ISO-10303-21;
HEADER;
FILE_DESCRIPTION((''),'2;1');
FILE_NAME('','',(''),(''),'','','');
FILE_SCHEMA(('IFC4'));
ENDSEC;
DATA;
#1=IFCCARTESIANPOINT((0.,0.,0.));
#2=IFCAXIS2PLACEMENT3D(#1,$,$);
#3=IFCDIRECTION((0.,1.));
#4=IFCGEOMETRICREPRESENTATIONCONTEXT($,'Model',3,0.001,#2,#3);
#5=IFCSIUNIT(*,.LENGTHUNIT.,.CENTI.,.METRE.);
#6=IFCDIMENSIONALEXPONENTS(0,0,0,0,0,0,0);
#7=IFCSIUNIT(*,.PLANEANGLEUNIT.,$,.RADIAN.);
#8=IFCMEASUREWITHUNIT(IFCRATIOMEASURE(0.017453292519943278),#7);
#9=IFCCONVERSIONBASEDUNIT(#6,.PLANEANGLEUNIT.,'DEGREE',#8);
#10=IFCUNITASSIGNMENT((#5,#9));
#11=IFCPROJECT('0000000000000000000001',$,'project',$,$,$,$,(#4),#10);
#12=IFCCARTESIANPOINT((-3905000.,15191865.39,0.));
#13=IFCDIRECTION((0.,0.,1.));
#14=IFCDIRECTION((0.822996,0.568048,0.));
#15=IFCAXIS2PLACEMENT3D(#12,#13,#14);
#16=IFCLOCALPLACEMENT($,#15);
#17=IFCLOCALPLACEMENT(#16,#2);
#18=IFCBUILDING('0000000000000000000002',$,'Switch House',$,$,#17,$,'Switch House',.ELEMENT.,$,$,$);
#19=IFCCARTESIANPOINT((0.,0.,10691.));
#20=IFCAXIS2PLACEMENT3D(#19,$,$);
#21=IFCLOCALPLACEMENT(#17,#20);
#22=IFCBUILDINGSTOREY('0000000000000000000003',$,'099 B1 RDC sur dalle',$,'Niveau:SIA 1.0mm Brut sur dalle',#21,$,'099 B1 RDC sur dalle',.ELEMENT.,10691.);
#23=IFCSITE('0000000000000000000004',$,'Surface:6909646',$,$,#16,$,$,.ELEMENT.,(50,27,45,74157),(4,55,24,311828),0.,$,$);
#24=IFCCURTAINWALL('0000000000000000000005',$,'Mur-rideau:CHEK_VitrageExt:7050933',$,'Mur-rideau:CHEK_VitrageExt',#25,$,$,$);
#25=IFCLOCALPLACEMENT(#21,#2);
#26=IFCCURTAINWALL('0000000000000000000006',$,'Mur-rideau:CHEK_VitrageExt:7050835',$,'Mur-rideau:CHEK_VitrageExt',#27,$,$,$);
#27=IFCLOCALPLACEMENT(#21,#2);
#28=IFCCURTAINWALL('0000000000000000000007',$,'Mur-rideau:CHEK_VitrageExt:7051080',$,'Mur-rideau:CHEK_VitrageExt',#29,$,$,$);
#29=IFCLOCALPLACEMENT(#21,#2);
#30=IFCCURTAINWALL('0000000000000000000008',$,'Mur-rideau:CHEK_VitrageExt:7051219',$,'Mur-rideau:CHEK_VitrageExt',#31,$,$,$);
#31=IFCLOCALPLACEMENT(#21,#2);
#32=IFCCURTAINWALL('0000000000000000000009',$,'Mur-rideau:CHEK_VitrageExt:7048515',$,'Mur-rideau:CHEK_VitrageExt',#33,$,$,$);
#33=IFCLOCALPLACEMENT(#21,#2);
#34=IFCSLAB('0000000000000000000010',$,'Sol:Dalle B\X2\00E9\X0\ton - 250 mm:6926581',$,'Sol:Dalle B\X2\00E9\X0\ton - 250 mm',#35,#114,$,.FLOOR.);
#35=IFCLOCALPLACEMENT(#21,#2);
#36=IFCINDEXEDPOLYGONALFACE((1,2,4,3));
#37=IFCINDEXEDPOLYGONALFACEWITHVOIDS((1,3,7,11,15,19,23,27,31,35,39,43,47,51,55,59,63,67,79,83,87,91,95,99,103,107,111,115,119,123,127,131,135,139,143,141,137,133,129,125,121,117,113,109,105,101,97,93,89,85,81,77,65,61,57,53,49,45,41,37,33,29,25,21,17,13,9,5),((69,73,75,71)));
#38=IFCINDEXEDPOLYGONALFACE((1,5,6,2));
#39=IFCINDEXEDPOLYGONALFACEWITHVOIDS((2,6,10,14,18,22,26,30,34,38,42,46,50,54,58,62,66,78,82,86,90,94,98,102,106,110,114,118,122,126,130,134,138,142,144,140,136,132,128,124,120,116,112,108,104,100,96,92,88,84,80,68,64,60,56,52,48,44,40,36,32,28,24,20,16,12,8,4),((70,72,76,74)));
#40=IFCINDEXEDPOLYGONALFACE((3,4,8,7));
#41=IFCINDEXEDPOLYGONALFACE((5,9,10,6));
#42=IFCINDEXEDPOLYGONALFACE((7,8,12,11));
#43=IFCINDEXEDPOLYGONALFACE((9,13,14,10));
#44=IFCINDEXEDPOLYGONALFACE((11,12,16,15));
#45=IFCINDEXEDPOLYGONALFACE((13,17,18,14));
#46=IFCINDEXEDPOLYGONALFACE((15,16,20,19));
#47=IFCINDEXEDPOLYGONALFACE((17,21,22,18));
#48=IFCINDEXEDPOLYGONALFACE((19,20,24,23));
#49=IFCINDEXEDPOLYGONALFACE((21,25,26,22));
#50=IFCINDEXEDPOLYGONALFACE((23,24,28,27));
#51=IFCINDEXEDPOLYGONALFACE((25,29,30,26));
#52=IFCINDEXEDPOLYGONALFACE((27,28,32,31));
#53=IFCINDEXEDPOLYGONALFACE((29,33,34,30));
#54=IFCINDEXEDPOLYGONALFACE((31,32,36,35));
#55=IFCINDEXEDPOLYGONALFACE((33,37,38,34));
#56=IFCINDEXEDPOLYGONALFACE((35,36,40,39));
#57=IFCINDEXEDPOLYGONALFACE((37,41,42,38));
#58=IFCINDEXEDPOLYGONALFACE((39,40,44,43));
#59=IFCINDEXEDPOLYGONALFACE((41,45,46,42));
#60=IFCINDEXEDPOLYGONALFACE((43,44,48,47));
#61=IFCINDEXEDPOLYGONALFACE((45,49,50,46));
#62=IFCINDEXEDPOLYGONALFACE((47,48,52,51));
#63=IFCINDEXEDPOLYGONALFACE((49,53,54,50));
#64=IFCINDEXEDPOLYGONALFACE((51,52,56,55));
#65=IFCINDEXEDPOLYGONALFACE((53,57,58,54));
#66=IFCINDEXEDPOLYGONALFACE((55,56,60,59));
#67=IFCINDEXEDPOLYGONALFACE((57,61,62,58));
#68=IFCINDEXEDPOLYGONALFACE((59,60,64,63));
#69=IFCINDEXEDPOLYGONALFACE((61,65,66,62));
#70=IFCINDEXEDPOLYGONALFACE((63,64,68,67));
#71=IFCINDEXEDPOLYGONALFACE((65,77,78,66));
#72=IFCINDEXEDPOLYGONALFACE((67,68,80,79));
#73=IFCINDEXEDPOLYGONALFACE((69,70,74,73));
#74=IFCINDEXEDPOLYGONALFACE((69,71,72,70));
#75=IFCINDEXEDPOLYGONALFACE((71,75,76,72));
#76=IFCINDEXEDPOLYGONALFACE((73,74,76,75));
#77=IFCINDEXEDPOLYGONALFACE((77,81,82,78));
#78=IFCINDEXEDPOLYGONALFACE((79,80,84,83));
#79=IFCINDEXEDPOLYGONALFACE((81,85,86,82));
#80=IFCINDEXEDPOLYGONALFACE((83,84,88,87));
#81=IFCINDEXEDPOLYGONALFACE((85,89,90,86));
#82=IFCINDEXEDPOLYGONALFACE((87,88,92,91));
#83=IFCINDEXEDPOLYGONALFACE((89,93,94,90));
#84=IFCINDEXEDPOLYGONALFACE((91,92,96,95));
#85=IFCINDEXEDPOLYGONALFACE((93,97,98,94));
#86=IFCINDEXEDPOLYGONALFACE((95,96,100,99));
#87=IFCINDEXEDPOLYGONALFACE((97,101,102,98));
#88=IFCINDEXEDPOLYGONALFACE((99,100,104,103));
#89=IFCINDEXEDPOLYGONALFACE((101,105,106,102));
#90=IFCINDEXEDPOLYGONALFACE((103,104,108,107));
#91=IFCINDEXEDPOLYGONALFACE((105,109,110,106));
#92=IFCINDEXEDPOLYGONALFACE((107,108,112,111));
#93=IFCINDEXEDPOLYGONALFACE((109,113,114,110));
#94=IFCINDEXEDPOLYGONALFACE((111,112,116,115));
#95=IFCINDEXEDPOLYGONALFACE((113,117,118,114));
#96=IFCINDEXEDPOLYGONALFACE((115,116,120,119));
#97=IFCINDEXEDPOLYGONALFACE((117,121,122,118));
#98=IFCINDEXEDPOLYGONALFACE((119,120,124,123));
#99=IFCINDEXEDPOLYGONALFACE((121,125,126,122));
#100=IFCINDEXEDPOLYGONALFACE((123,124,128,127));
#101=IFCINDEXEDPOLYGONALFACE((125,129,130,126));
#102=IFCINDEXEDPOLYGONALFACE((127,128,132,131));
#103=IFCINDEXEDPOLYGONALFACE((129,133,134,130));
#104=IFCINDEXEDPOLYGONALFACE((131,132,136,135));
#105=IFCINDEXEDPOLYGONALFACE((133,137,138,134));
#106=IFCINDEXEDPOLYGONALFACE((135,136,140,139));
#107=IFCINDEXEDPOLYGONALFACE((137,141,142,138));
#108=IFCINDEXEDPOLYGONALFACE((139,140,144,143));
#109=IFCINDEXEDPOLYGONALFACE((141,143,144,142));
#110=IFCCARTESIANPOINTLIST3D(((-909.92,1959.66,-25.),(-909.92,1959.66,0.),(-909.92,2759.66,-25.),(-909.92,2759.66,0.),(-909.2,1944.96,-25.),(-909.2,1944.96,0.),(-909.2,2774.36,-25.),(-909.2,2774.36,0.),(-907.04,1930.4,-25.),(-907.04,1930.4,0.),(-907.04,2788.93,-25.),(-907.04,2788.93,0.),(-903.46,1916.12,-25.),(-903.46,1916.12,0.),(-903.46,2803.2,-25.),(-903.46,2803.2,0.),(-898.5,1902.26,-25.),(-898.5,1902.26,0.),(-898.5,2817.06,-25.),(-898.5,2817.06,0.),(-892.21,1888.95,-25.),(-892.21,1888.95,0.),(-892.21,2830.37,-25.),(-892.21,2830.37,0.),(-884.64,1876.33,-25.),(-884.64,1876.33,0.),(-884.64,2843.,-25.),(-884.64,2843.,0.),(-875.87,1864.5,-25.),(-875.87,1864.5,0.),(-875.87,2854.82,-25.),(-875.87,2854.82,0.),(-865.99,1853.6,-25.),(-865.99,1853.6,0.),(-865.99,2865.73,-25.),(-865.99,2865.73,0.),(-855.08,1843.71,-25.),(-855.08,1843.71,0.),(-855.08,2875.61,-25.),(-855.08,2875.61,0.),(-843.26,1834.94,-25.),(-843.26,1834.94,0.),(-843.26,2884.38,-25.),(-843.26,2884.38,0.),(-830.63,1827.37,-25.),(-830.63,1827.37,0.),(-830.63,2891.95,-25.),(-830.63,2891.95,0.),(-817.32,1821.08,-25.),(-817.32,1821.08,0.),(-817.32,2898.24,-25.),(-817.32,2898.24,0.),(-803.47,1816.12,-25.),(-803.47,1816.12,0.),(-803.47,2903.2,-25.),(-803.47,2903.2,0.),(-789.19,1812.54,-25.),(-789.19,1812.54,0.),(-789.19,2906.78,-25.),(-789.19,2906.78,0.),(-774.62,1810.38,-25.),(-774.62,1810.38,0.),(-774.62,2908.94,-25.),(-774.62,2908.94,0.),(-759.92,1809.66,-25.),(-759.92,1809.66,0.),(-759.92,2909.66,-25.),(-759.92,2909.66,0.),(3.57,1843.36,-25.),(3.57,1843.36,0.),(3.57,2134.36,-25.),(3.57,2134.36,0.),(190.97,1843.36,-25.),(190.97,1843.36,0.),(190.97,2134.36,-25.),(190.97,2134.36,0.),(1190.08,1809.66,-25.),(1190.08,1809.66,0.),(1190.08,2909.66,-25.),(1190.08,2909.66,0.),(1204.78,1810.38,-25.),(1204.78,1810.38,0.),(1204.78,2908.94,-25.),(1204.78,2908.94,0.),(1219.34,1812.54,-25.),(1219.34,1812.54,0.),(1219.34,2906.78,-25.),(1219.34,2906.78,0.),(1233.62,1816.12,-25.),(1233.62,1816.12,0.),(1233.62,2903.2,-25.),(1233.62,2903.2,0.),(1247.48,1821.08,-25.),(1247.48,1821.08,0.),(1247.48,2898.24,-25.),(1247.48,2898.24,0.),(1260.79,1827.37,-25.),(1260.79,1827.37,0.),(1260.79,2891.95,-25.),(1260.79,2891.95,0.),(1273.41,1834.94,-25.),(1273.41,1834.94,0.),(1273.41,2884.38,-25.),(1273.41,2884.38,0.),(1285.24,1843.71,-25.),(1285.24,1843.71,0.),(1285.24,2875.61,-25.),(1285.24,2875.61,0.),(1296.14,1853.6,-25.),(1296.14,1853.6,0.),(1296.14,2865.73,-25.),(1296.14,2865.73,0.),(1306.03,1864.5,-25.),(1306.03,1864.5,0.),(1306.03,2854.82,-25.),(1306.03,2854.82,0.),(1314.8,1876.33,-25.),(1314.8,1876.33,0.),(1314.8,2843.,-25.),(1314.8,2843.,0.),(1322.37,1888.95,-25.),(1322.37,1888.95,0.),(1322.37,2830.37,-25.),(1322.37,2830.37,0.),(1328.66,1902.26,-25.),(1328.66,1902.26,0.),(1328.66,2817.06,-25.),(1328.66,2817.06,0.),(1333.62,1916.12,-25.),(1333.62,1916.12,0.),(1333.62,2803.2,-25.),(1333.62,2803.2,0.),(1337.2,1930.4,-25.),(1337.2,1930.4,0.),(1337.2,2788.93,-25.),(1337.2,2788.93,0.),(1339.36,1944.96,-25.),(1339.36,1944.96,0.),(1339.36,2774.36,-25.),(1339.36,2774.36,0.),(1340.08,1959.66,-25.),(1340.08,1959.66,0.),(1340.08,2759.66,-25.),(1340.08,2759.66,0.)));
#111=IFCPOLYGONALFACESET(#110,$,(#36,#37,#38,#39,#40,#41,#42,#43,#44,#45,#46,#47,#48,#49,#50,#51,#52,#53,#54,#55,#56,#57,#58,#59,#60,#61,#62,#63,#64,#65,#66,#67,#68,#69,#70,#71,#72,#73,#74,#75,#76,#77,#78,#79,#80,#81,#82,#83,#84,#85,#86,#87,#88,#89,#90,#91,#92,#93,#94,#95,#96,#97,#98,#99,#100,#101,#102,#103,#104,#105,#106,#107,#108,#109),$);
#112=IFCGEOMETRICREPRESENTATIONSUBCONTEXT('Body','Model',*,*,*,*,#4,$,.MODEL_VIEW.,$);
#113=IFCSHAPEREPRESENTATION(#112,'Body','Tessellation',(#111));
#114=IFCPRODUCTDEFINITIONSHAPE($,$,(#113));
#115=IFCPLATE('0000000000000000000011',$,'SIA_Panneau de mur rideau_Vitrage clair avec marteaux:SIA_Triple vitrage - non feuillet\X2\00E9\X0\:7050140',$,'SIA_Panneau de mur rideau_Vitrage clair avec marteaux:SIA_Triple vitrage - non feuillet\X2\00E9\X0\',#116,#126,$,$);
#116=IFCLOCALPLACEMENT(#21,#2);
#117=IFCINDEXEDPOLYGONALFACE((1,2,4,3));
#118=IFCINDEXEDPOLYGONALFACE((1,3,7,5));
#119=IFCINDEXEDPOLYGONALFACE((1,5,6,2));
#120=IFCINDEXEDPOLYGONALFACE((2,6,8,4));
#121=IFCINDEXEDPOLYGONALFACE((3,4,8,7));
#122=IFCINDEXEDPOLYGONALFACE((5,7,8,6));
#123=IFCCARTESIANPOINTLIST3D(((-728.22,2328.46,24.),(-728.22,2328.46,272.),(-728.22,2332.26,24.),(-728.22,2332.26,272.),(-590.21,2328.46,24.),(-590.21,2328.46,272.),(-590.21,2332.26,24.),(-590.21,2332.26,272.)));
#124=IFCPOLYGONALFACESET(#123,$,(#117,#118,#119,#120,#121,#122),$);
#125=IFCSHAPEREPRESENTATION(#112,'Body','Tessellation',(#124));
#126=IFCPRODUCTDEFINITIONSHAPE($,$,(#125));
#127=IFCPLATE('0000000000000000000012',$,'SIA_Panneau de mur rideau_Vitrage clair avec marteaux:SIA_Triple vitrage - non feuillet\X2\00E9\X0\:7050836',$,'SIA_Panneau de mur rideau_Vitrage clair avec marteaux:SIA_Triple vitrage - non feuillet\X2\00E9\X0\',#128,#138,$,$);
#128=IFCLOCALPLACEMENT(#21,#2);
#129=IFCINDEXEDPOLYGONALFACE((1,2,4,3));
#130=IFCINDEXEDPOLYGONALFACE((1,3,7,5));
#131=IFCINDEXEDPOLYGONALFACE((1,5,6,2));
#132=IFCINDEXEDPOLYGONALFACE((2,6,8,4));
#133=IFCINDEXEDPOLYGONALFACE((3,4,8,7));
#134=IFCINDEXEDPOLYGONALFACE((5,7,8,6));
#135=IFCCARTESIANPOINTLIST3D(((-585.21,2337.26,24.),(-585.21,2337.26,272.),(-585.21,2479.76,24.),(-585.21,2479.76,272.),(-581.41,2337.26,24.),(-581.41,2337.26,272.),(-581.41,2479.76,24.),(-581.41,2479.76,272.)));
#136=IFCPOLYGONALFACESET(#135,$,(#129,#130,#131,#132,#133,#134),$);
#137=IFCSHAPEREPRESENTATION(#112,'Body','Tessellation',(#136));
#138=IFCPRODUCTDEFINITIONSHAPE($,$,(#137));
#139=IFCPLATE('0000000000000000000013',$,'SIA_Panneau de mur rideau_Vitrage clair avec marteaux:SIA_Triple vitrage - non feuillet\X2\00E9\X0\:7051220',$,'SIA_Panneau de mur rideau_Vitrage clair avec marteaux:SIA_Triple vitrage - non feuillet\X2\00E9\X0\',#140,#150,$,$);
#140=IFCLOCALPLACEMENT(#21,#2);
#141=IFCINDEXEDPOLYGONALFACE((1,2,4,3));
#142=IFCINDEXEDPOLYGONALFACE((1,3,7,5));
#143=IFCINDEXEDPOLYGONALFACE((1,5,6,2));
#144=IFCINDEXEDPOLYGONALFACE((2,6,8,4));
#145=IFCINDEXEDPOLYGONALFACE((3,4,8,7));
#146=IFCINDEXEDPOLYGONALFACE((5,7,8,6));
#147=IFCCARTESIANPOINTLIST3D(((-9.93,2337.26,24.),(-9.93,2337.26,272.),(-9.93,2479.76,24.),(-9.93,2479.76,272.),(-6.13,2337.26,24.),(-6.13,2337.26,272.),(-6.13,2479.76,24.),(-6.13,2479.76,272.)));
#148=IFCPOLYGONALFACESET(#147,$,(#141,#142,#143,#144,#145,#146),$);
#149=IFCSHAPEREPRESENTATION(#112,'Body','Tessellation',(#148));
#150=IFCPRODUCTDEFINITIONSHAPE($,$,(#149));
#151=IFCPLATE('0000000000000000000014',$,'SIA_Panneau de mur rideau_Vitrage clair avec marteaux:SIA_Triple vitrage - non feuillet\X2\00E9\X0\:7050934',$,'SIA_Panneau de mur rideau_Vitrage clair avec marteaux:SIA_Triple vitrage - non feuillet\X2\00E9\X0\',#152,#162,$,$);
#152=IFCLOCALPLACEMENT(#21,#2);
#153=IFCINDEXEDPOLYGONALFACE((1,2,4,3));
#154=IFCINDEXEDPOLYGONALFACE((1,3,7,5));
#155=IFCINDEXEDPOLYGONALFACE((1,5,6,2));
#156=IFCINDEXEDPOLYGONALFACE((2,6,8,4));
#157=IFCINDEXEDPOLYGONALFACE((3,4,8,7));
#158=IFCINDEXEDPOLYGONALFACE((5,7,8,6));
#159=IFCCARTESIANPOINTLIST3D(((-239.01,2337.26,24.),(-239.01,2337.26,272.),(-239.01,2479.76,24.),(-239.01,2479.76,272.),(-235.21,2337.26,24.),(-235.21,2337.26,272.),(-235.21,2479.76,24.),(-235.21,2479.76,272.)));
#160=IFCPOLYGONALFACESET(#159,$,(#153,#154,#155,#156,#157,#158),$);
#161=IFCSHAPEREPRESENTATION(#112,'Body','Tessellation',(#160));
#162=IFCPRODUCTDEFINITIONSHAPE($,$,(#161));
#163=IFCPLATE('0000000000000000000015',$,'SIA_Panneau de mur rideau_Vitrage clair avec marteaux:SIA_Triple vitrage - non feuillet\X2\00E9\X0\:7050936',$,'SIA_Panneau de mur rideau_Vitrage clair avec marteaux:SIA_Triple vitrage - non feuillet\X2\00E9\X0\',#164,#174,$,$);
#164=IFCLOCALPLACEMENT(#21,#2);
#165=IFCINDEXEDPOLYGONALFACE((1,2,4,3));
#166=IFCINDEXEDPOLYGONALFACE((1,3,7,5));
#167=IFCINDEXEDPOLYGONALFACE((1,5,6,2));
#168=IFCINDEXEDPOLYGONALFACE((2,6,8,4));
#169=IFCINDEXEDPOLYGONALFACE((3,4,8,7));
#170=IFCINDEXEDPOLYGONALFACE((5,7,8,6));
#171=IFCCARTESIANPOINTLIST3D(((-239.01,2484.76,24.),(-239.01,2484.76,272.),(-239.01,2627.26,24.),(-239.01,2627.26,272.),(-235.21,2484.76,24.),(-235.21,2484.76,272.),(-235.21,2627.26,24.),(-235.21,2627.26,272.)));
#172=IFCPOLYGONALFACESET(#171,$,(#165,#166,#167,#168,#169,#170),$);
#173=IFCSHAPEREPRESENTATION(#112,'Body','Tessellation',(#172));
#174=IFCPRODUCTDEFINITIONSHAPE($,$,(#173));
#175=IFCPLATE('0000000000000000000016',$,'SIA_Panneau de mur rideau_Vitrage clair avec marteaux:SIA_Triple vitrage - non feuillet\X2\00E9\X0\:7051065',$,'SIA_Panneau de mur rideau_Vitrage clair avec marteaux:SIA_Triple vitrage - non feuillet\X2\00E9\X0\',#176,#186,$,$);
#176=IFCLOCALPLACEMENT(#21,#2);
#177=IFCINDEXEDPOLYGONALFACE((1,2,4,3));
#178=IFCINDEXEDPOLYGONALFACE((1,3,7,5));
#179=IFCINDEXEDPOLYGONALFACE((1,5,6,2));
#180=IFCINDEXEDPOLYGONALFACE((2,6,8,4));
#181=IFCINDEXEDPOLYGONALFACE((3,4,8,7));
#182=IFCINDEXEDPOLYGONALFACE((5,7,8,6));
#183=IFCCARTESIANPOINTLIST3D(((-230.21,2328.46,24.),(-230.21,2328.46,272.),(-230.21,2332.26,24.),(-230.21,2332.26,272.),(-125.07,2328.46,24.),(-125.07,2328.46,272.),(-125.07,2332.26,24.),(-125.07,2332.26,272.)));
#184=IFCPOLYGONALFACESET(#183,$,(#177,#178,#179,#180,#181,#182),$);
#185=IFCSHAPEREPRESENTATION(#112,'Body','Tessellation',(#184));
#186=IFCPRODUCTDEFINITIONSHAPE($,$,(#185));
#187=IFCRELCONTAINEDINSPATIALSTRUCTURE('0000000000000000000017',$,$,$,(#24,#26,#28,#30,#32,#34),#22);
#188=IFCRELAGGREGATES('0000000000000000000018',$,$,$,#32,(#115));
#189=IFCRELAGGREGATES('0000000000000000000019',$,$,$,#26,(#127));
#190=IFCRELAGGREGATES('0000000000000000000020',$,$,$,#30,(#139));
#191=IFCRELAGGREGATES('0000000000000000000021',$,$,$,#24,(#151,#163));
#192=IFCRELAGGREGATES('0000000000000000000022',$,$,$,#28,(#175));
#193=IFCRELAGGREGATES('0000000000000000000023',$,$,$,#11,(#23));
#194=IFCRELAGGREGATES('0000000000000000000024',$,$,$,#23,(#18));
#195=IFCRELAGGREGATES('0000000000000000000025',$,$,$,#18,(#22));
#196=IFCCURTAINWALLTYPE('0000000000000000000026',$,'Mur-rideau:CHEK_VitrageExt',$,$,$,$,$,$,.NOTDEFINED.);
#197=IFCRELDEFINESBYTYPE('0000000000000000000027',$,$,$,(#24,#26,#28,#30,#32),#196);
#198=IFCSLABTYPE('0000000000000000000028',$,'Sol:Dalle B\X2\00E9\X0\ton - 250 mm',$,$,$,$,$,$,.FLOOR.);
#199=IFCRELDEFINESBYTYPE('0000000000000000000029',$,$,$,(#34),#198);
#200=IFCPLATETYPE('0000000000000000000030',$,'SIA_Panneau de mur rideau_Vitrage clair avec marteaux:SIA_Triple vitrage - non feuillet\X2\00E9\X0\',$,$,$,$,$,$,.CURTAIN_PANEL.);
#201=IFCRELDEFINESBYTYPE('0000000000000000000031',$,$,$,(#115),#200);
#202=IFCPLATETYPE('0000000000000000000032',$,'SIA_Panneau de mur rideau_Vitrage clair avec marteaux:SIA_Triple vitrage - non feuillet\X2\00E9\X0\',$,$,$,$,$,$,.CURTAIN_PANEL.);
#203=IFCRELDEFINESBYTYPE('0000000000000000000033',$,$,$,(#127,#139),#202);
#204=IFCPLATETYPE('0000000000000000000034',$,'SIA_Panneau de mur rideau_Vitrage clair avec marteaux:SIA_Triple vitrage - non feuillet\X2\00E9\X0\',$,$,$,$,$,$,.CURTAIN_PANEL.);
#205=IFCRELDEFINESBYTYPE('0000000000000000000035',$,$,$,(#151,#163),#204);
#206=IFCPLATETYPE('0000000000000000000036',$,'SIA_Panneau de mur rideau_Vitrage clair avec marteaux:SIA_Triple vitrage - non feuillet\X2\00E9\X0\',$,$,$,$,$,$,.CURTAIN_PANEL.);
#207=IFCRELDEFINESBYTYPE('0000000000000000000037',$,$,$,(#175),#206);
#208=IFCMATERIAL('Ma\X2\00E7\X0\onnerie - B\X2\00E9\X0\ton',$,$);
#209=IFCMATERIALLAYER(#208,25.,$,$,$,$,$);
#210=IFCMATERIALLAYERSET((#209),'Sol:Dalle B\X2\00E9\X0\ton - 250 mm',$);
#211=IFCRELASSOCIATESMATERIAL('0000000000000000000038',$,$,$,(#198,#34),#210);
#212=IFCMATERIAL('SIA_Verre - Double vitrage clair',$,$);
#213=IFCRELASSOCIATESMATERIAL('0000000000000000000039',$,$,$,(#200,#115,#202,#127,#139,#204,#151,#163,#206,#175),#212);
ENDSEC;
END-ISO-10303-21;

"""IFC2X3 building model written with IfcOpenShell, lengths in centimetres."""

from ifc_helpers import new_model, entity, si_unit, converted_unit, direction, frame, frame_2d, origin, origin_2d_with_axis, place, context, subcontext, project, spatial, polyline, circle_curve, parameter, trimmed, segment, composite_curve, rectangle, outline, extrude, source, transform, mapped, material, layer, layer_set, layer_usage, type_object, type_shapes, element, aggregate, save


model = new_model("IFC2X3")

# Units and contexts
model_context = context("Model", 3, precision=0.001, world=origin(), true_north=direction((0.0, 1.0)))
body_context = subcontext(model_context, "Body", "Model", "MODEL_VIEW")
ifc_project = project(units=[si_unit("LENGTHUNIT", "METRE", prefix="CENTI"), converted_unit("PLANEANGLEUNIT", "DEGREE", entity("IfcRatioMeasure", 0.017453292519943278), si_unit("PLANEANGLEUNIT", "RADIAN"), dimensions=[0, 0, 0, 0, 0, 0, 0])], contexts=[model_context])

# Site, building, storey
site_placement = place(None, frame((-3905000.0, 15191865.39, 0.0), z_axis=(0.0, 0.0, 1.0), x_axis=(0.822996, 0.568048, 0.0)))
site = spatial("IfcSite", under=ifc_project, at=site_placement, Name="Surface:6909646", CompositionType="ELEMENT", RefLatitude=(50, 27, 45, 74157), RefLongitude=(4, 55, 24, 311828), RefElevation=0.0)
building_placement = place(site_placement, origin())
building = spatial("IfcBuilding", under=site, at=building_placement, Name="Switch House", LongName="Switch House", CompositionType="ELEMENT")
storey_placement = place(building_placement, frame((0.0, 0.0, 10691.0)))
storey = spatial("IfcBuildingStorey", under=building, at=storey_placement, Name="099 B1 RDC sur dalle", ObjectType="Niveau:SIA 1.0mm Brut sur dalle", LongName="099 B1 RDC sur dalle", CompositionType="ELEMENT", Elevation=10691.0)

# Curtain wall
curtain_wall_type = type_object("IfcCurtainWallType", Name="Mur-rideau:CHEK_VitrageExt", PredefinedType="NOTDEFINED")
curtain_wall_1_placement = place(storey_placement, frame((0.0, 0.0, -10691.0)))
curtain_wall_1 = element("IfcCurtainWall", 1, at=curtain_wall_1_placement, inside=storey, type_object=curtain_wall_type, Name="Mur-rideau:CHEK_VitrageExt:7050933", ObjectType="Mur-rideau:CHEK_VitrageExt")

# Curtain walls
curtain_wall_2_placement = place(storey_placement, frame((0.0, 0.0, -10691.0)))
curtain_wall_2 = element("IfcCurtainWall", 2, at=curtain_wall_2_placement, inside=storey, type_object=curtain_wall_type, Name="Mur-rideau:CHEK_VitrageExt:7050835", ObjectType="Mur-rideau:CHEK_VitrageExt")
curtain_wall_3_placement = place(storey_placement, frame((0.0, 0.0, -10691.0)))
curtain_wall_3 = element("IfcCurtainWall", 3, at=curtain_wall_3_placement, inside=storey, type_object=curtain_wall_type, Name="Mur-rideau:CHEK_VitrageExt:7051080", ObjectType="Mur-rideau:CHEK_VitrageExt")
curtain_wall_4_placement = place(storey_placement, frame((0.0, 0.0, -10691.0)))
curtain_wall_4 = element("IfcCurtainWall", 4, at=curtain_wall_4_placement, inside=storey, type_object=curtain_wall_type, Name="Mur-rideau:CHEK_VitrageExt:7051219", ObjectType="Mur-rideau:CHEK_VitrageExt")

# Curtain wall
curtain_wall_5_placement = place(storey_placement, frame((0.0, 0.0, -10691.0)))
curtain_wall_5 = element("IfcCurtainWall", 5, at=curtain_wall_5_placement, inside=storey, type_object=curtain_wall_type, Name="Mur-rideau:CHEK_VitrageExt:7048515", ObjectType="Mur-rideau:CHEK_VitrageExt")

# Slab, opening
ifc_material_1 = material(Name="Maçonnerie - Béton")
ifc_layer_1 = layer(ifc_material_1, 25.0)
ifc_layer_set_1 = layer_set([ifc_layer_1], Name="Sol:Dalle Béton - 250 mm")
ifc_layer_usage_1 = layer_usage(ifc_layer_set_1, "AXIS3", "POSITIVE", 0.0)
slab_type = type_object("IfcSlabType", Name="Sol:Dalle Béton - 250 mm", PredefinedType="FLOOR", material=ifc_layer_set_1)
slab_placement = place(storey_placement, frame((-909.92, 1809.66, -25.0)))
slab = element("IfcSlab", 6, at=slab_placement, inside=storey, type_object=slab_type, material=ifc_layer_usage_1, Name="Sol:Dalle Béton - 250 mm:6926581", ObjectType="Sol:Dalle Béton - 250 mm", PredefinedType="FLOOR", context=body_context, shape_type="SweptSolid", body=[
    extrude(outline(composite_curve([segment(trimmed(circle_curve(frame_2d((975.0, 400.0), x_axis=(-1.0, 0.0)), 150.0), [parameter(180.0)], [parameter(270.0)], True, "PARAMETER"), True, "CONTINUOUS"), segment(polyline([(975.0, 550.0), (-975.0, 550.0)]), True, "CONTINUOUS"), segment(trimmed(circle_curve(frame_2d((-975.0, 400.0), x_axis=(-1.0, 0.0)), 150.0), [parameter(270.0)], [parameter(0.0)], True, "PARAMETER"), True, "CONTINUOUS"), segment(polyline([(-1125.0, 400.0), (-1125.0, -400.0)]), True, "CONTINUOUS"), segment(trimmed(circle_curve(frame_2d((-975.0, -400.0), x_axis=(-1.0, 0.0)), 150.0), [parameter(0.0)], [parameter(90.0)], True, "PARAMETER"), True, "CONTINUOUS"), segment(polyline([(-975.0, -550.0), (975.0, -550.0)]), True, "CONTINUOUS"), segment(trimmed(circle_curve(frame_2d((975.0, -400.0), x_axis=(-1.0, 0.0)), 150.0), [parameter(90.0)], [parameter(180.0)], True, "PARAMETER"), True, "CONTINUOUS"), segment(polyline([(1125.0, -400.0), (1125.0, 400.0)]), True, "CONTINUOUS")], self_intersect=False)), frame((1125.0, 550.0, 25.0), z_axis=(0.0, 0.0, -1.0), x_axis=(-1.0, 0.0, 0.0)), (0.0, 0.0, 1.0), 25.0),
])
opening_placement = place(storey_placement, frame((-909.92, 1809.66, -25.0)))
element("IfcOpeningElement", 7, at=opening_placement, cuts=slab, ObjectType="Opening", context=body_context, shape_type="SweptSolid", body=[
    extrude(rectangle(XDim=291.0, YDim=187.4, at=frame_2d((117.81, -370.8), x_axis=(0.0, -1.0))), frame((1125.0, 550.0, 25.0), z_axis=(0.0, 0.0, -1.0), x_axis=(-1.0, 0.0, 0.0)), (0.0, 0.0, 1.0), 25.0),
])

# Plates
ifc_material_2 = material(Name="SIA_Verre - Double vitrage clair")
plate_type_1 = type_object("IfcPlateType", Name="SIA_Panneau de mur rideau_Vitrage clair avec marteaux:SIA_Triple vitrage - non feuilleté", PredefinedType="CURTAIN_PANEL", material=ifc_material_2)
shared_shape_1 = source(origin(), body_context, "Body", "SweptSolid", [
    extrude(rectangle(XDim=3.8, YDim=138.01, at=origin_2d_with_axis()), frame((0.0, -1.9, 0.0), z_axis=(0.0, 0.0, 1.0), x_axis=(0.0, 1.0, 0.0)), (0.0, 0.0, 1.0), 248.0),
])
type_shapes(plate_type_1, [shared_shape_1])
plate_1_placement = place(curtain_wall_5_placement, frame((-659.21, 2332.26, 10715.0)))
plate_1 = element("IfcPlate", 8, at=plate_1_placement, type_object=plate_type_1, material=ifc_material_2, Name="SIA_Panneau de mur rideau_Vitrage clair avec marteaux:SIA_Triple vitrage - non feuilleté:7050140", ObjectType="SIA_Panneau de mur rideau_Vitrage clair avec marteaux:SIA_Triple vitrage - non feuilleté", context=body_context, shape_type="MappedRepresentation", body=[
    mapped(shared_shape_1, transform((0.0, 0.0, 0.0), scale=1.0)),
])
aggregate(curtain_wall_5, [plate_1])
plate_type_2 = type_object("IfcPlateType", Name="SIA_Panneau de mur rideau_Vitrage clair avec marteaux:SIA_Triple vitrage - non feuilleté", PredefinedType="CURTAIN_PANEL", material=ifc_material_2)
shared_shape_2 = source(origin(), body_context, "Body", "SweptSolid", [
    extrude(rectangle(XDim=3.8, YDim=142.5, at=origin_2d_with_axis()), frame((0.0, -1.9, 0.0), z_axis=(0.0, 0.0, 1.0), x_axis=(0.0, 1.0, 0.0)), (0.0, 0.0, 1.0), 248.0),
])
type_shapes(plate_type_2, [shared_shape_2])
plate_2_placement = place(curtain_wall_2_placement, frame((-585.21, 2408.51, 10715.0), z_axis=(0.0, 0.0, 1.0), x_axis=(0.0, 1.0, 0.0)))
plate_2 = element("IfcPlate", 9, at=plate_2_placement, type_object=plate_type_2, material=ifc_material_2, Name="SIA_Panneau de mur rideau_Vitrage clair avec marteaux:SIA_Triple vitrage - non feuilleté:7050836", ObjectType="SIA_Panneau de mur rideau_Vitrage clair avec marteaux:SIA_Triple vitrage - non feuilleté", context=body_context, shape_type="MappedRepresentation", body=[
    mapped(shared_shape_2, transform((0.0, 0.0, 0.0), scale=1.0)),
])
aggregate(curtain_wall_2, [plate_2])
plate_3_placement = place(curtain_wall_4_placement, frame((-9.93, 2408.51, 10715.0), z_axis=(0.0, 0.0, 1.0), x_axis=(0.0, 1.0, 0.0)))
plate_3 = element("IfcPlate", 10, at=plate_3_placement, type_object=plate_type_2, material=ifc_material_2, Name="SIA_Panneau de mur rideau_Vitrage clair avec marteaux:SIA_Triple vitrage - non feuilleté:7051220", ObjectType="SIA_Panneau de mur rideau_Vitrage clair avec marteaux:SIA_Triple vitrage - non feuilleté", context=body_context, shape_type="MappedRepresentation", body=[
    mapped(shared_shape_2, transform((0.0, 0.0, 0.0), scale=1.0)),
])
aggregate(curtain_wall_4, [plate_3])
plate_type_3 = type_object("IfcPlateType", Name="SIA_Panneau de mur rideau_Vitrage clair avec marteaux:SIA_Triple vitrage - non feuilleté", PredefinedType="CURTAIN_PANEL", material=ifc_material_2)
shared_shape_3 = source(origin(), body_context, "Body", "SweptSolid", [
    extrude(rectangle(XDim=142.5, YDim=3.8, at=origin_2d_with_axis()), frame((0.0, 1.9, 0.0), z_axis=(0.0, 0.0, 1.0), x_axis=(-1.0, 0.0, 0.0)), (0.0, 0.0, 1.0), 248.0),
])
type_shapes(plate_type_3, [shared_shape_3])
plate_4_placement = place(curtain_wall_1_placement, frame((-235.21, 2408.51, 10715.0), z_axis=(0.0, 0.0, 1.0), x_axis=(0.0, 1.0, 0.0)))
plate_4 = element("IfcPlate", 11, at=plate_4_placement, type_object=plate_type_3, material=ifc_material_2, Name="SIA_Panneau de mur rideau_Vitrage clair avec marteaux:SIA_Triple vitrage - non feuilleté:7050934", ObjectType="SIA_Panneau de mur rideau_Vitrage clair avec marteaux:SIA_Triple vitrage - non feuilleté", context=body_context, shape_type="MappedRepresentation", body=[
    mapped(shared_shape_3, transform((0.0, 0.0, 0.0), scale=1.0)),
])
plate_5_placement = place(curtain_wall_1_placement, frame((-235.21, 2556.01, 10715.0), z_axis=(0.0, 0.0, 1.0), x_axis=(0.0, 1.0, 0.0)))
plate_5 = element("IfcPlate", 12, at=plate_5_placement, type_object=plate_type_3, material=ifc_material_2, Name="SIA_Panneau de mur rideau_Vitrage clair avec marteaux:SIA_Triple vitrage - non feuilleté:7050936", ObjectType="SIA_Panneau de mur rideau_Vitrage clair avec marteaux:SIA_Triple vitrage - non feuilleté", context=body_context, shape_type="MappedRepresentation", body=[
    mapped(shared_shape_3, transform((0.0, 0.0, 0.0), scale=1.0)),
])
aggregate(curtain_wall_1, [plate_4, plate_5])
plate_type_4 = type_object("IfcPlateType", Name="SIA_Panneau de mur rideau_Vitrage clair avec marteaux:SIA_Triple vitrage - non feuilleté", PredefinedType="CURTAIN_PANEL", material=ifc_material_2)
shared_shape_4 = source(origin(), body_context, "Body", "SweptSolid", [
    extrude(rectangle(XDim=3.8, YDim=105.14, at=origin_2d_with_axis()), frame((0.0, -1.9, 0.0), z_axis=(0.0, 0.0, 1.0), x_axis=(0.0, 1.0, 0.0)), (0.0, 0.0, 1.0), 248.0),
])
type_shapes(plate_type_4, [shared_shape_4])
plate_6_placement = place(curtain_wall_3_placement, frame((-177.64, 2332.26, 10715.0)))
plate_6 = element("IfcPlate", 13, at=plate_6_placement, type_object=plate_type_4, material=ifc_material_2, Name="SIA_Panneau de mur rideau_Vitrage clair avec marteaux:SIA_Triple vitrage - non feuilleté:7051065", ObjectType="SIA_Panneau de mur rideau_Vitrage clair avec marteaux:SIA_Triple vitrage - non feuilleté", context=body_context, shape_type="MappedRepresentation", body=[
    mapped(shared_shape_4, transform((0.0, 0.0, 0.0), scale=1.0)),
])
aggregate(curtain_wall_3, [plate_6])

save(model, "model.ifc")
